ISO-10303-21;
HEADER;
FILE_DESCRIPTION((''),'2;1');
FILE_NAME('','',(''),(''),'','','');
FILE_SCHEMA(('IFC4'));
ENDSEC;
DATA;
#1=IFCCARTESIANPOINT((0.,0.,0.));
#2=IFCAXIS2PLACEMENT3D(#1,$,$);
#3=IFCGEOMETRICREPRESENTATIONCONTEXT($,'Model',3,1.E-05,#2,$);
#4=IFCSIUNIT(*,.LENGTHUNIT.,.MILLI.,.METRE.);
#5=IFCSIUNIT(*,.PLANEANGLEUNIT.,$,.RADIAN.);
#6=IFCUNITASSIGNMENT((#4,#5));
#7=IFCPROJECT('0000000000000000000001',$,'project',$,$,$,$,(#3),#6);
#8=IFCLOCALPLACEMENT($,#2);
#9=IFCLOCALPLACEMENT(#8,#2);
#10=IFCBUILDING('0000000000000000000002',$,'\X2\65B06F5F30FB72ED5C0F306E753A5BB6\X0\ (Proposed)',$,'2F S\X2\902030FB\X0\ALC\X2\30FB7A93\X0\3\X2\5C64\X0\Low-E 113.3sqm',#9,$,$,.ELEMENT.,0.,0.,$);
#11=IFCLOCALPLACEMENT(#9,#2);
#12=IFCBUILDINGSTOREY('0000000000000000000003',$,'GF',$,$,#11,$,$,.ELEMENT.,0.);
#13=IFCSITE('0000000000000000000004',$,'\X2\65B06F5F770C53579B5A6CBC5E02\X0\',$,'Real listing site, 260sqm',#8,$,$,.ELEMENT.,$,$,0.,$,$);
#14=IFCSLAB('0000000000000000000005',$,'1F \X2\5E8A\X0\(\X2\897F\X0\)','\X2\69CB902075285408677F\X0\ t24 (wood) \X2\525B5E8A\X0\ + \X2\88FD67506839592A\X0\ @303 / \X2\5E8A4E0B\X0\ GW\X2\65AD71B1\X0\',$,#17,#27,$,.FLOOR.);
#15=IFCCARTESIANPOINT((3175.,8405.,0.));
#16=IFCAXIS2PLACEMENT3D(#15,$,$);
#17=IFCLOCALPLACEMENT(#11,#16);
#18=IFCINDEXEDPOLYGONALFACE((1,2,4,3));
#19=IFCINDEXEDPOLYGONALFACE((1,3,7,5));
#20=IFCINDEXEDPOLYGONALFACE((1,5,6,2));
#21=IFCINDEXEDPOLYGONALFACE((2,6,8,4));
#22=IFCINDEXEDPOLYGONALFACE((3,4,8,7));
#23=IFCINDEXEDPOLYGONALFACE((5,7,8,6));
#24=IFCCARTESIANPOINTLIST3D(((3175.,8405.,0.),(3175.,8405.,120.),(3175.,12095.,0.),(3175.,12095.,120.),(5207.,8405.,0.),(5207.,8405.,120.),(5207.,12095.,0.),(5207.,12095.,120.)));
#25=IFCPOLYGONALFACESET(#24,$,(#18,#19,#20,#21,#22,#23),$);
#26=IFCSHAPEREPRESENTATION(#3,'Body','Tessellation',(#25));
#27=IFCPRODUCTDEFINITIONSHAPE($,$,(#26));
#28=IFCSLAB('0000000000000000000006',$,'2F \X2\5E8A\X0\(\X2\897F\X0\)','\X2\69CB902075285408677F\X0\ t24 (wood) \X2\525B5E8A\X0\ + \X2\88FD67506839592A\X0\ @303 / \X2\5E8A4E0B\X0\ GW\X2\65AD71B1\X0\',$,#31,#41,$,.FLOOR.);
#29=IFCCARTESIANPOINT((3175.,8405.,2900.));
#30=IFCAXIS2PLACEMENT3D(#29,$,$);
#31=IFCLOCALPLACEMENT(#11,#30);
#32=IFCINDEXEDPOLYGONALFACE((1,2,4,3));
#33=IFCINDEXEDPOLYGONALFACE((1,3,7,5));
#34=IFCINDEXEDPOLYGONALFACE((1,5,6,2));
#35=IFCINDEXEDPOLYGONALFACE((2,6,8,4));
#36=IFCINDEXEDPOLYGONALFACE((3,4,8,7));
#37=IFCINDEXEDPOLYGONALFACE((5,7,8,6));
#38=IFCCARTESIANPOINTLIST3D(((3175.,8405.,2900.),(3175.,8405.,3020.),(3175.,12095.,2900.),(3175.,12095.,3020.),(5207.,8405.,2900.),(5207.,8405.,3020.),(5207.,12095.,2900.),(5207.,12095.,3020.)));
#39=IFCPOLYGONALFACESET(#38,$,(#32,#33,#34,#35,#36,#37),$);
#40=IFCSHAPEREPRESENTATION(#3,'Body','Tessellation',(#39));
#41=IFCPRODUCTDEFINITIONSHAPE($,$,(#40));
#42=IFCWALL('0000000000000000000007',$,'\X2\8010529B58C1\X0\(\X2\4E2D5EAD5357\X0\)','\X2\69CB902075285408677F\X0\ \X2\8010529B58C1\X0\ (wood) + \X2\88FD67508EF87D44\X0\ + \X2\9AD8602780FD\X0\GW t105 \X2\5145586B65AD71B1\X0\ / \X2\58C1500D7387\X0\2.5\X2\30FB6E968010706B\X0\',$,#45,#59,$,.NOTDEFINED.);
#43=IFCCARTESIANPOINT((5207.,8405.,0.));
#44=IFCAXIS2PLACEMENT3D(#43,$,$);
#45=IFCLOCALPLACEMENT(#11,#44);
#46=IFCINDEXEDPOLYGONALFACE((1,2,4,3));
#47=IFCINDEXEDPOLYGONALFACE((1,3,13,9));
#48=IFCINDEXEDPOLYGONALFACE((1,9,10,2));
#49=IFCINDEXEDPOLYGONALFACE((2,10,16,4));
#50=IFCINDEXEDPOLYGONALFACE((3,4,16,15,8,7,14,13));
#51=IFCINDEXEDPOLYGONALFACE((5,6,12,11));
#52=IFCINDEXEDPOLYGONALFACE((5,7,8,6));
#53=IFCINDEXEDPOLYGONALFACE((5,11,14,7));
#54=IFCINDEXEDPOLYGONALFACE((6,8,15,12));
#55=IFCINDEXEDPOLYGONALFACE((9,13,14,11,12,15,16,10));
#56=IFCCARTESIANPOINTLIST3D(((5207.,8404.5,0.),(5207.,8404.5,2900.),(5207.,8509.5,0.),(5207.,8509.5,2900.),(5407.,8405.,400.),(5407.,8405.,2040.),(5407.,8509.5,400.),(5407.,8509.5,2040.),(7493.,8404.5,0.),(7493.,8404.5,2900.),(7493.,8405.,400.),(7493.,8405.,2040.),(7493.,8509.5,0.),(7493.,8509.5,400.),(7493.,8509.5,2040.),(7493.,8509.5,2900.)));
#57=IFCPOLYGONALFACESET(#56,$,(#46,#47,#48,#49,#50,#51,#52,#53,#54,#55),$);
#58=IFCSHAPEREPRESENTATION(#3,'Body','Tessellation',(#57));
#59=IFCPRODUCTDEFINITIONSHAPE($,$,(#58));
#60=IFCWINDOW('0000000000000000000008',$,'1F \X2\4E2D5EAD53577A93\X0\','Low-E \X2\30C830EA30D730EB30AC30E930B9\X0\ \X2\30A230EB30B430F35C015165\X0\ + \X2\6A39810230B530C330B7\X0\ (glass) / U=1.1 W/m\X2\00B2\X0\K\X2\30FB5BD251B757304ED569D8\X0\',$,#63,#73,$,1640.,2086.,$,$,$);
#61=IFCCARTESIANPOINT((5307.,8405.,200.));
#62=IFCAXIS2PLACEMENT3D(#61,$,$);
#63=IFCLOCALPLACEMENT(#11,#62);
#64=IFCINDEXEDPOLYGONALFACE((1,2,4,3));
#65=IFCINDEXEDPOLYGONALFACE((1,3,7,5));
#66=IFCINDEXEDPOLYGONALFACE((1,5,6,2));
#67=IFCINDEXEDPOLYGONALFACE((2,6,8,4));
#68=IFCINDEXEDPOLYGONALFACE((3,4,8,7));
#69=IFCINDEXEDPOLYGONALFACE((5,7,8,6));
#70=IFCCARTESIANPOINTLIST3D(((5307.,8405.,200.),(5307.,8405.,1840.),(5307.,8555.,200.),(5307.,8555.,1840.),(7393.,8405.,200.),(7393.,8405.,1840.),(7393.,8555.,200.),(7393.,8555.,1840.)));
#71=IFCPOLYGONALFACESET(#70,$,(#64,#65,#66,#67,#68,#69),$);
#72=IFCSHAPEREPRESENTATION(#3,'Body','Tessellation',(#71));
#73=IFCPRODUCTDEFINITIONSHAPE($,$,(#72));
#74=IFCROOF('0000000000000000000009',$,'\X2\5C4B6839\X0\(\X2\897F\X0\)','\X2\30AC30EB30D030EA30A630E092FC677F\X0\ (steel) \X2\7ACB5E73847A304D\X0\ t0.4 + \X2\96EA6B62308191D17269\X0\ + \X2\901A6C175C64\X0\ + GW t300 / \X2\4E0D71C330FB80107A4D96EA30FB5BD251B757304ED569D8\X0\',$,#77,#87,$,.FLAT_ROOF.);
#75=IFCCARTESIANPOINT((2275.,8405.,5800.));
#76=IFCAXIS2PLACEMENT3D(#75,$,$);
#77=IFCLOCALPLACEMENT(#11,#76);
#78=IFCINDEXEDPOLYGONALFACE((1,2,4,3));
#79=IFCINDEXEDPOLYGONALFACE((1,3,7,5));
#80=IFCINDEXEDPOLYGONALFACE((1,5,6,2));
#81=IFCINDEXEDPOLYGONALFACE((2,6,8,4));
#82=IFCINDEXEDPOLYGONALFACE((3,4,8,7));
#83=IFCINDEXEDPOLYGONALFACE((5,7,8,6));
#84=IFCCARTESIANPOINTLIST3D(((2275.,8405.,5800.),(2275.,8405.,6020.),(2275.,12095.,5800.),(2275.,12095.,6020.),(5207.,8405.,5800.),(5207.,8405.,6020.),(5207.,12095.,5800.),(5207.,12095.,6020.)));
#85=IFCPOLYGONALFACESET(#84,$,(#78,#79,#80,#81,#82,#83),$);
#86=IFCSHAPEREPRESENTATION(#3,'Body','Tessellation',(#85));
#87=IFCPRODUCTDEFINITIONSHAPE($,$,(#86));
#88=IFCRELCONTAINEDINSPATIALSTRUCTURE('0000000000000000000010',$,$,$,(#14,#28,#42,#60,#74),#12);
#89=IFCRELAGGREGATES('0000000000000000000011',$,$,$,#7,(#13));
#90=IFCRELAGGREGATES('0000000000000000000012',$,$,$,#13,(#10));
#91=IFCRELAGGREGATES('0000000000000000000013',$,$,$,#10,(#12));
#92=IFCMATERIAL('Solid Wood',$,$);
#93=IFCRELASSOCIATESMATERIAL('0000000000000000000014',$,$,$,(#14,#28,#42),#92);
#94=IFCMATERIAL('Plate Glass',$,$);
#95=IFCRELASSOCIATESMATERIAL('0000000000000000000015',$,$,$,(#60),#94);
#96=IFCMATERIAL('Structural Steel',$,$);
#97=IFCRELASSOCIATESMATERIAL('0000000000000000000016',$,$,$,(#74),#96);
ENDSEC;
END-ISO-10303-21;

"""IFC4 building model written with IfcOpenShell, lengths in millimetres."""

from ifc_helpers import new_model, si_unit, frame, frame_2d, origin, place, context, project, spatial, rectangle, extrude, material, element, fill, save


model = new_model("IFC4")

# Units and contexts
model_context = context("Model", 3, precision=1e-05, world=origin())
ifc_project = project(units=[si_unit("LENGTHUNIT", "METRE", prefix="MILLI"), si_unit("PLANEANGLEUNIT", "RADIAN")], contexts=[model_context])

# Site, building, storey
site_placement = place(None, origin())
site = spatial("IfcSite", under=ifc_project, at=site_placement, Name="新潟県南魚沼市", ObjectType="Real listing site, 260sqm", CompositionType="ELEMENT", RefElevation=0.0)
building_placement = place(site_placement, origin())
building = spatial("IfcBuilding", under=site, at=building_placement, Name="新潟・狭小の町家 (Proposed)", ObjectType="2F S造・ALC・窓3層Low-E 113.3sqm", CompositionType="ELEMENT", ElevationOfRefHeight=0.0, ElevationOfTerrain=0.0)
storey_placement = place(building_placement, origin())
storey = spatial("IfcBuildingStorey", under=building, at=storey_placement, Name="GF", CompositionType="ELEMENT", Elevation=0.0)

# Shared definitions
ifc_material_1 = material(Name="Solid Wood")

# Slabs
slab_1_placement = place(storey_placement, frame((3175.0, 8405.0, 0.0)))
element("IfcSlab", 1, at=slab_1_placement, inside=storey, material=ifc_material_1, Name="1F 床(西)", Description="構造用合板 t24 (wood) 剛床 + 製材根太 @303 / 床下 GW断熱", PredefinedType="FLOOR", context=model_context, shape_type="SweptSolid", body=[
    extrude(rectangle(XDim=2032.0, YDim=3690.0, at=frame_2d((1016.0, 1845.0))), frame((3175.0, 8405.0, 0.0)), (0.0, 0.0, 1.0), 120.0),
])
slab_2_placement = place(storey_placement, frame((3175.0, 8405.0, 2900.0)))
element("IfcSlab", 2, at=slab_2_placement, inside=storey, material=ifc_material_1, Name="2F 床(西)", Description="構造用合板 t24 (wood) 剛床 + 製材根太 @303 / 床下 GW断熱", PredefinedType="FLOOR", context=model_context, shape_type="SweptSolid", body=[
    extrude(rectangle(XDim=2032.0, YDim=3690.0, at=frame_2d((1016.0, 1845.0))), frame((3175.0, 8405.0, 2900.0)), (0.0, 0.0, 1.0), 120.0),
])

# Wall, opening, window
wall_1_placement = place(storey_placement, frame((5207.0, 8405.0, 0.0)))
wall_1 = element("IfcWall", 3, at=wall_1_placement, inside=storey, material=ifc_material_1, Name="耐力壁(中庭南)", Description="構造用合板 耐力壁 (wood) + 製材軸組 + 高性能GW t105 充填断熱 / 壁倍率2.5・準耐火", PredefinedType="NOTDEFINED", context=model_context, shape_type="SweptSolid", body=[
    extrude(rectangle(XDim=2286.0, YDim=105.0, at=frame_2d((1143.0, 52.0))), frame((5207.0, 8405.0, 0.0)), (0.0, 0.0, 1.0), 2900.0),
])
opening_placement = place(storey_placement, frame((5307.0, 8405.0, 200.0)))
opening = element("IfcOpeningElement", 4, at=opening_placement, cuts=wall_1, PredefinedType="NOTDEFINED", context=model_context, shape_type="SweptSolid", body=[
    extrude(rectangle(XDim=2086.0, YDim=150.0, at=frame_2d((1043.0, 75.0))), frame((5307.0, 8405.0, 200.0)), (0.0, 0.0, 1.0), 1640.0),
])
ifc_material_2 = material(Name="Plate Glass")
window_placement = place(storey_placement, frame((5307.0, 8405.0, 200.0)))
window = element("IfcWindow", 5, at=window_placement, inside=storey, material=ifc_material_2, Name="1F 中庭南窓", Description="Low-E トリプルガラス アルゴン封入 + 樹脂サッシ (glass) / U=1.1 W/m²K・寒冷地仕様", OverallHeight=1640.0, OverallWidth=2086.0, context=model_context, shape_type="SweptSolid", body=[
    extrude(rectangle(XDim=2086.0, YDim=150.0, at=frame_2d((1043.0, 75.0))), frame((5307.0, 8405.0, 200.0)), (0.0, 0.0, 1.0), 1640.0),
])
fill(opening, window)

# Roof
ifc_material_3 = material(Name="Structural Steel")
for number, where, name in (
    (6, (2275.0, 8405.0, 5800.0), "屋根(西)"),
):
    element("IfcRoof", number, at=place(storey_placement, frame(where)), inside=storey, material=ifc_material_3, Name=name, Description="ガルバリウム鋼板 (steel) 立平葺き t0.4 + 雪止め金物 + 通気層 + GW t300 / 不燃・耐積雪・寒冷地仕様", PredefinedType="FLAT_ROOF", context=model_context, shape_type="SweptSolid", body=[
        extrude(rectangle(XDim=2932.0, YDim=3690.0, at=frame_2d((1466.0, 1845.0))), frame((2275.0, 8405.0, 5800.0)), (0.0, 0.0, 1.0), 220.0),
    ])

save(model, "model.ifc")
